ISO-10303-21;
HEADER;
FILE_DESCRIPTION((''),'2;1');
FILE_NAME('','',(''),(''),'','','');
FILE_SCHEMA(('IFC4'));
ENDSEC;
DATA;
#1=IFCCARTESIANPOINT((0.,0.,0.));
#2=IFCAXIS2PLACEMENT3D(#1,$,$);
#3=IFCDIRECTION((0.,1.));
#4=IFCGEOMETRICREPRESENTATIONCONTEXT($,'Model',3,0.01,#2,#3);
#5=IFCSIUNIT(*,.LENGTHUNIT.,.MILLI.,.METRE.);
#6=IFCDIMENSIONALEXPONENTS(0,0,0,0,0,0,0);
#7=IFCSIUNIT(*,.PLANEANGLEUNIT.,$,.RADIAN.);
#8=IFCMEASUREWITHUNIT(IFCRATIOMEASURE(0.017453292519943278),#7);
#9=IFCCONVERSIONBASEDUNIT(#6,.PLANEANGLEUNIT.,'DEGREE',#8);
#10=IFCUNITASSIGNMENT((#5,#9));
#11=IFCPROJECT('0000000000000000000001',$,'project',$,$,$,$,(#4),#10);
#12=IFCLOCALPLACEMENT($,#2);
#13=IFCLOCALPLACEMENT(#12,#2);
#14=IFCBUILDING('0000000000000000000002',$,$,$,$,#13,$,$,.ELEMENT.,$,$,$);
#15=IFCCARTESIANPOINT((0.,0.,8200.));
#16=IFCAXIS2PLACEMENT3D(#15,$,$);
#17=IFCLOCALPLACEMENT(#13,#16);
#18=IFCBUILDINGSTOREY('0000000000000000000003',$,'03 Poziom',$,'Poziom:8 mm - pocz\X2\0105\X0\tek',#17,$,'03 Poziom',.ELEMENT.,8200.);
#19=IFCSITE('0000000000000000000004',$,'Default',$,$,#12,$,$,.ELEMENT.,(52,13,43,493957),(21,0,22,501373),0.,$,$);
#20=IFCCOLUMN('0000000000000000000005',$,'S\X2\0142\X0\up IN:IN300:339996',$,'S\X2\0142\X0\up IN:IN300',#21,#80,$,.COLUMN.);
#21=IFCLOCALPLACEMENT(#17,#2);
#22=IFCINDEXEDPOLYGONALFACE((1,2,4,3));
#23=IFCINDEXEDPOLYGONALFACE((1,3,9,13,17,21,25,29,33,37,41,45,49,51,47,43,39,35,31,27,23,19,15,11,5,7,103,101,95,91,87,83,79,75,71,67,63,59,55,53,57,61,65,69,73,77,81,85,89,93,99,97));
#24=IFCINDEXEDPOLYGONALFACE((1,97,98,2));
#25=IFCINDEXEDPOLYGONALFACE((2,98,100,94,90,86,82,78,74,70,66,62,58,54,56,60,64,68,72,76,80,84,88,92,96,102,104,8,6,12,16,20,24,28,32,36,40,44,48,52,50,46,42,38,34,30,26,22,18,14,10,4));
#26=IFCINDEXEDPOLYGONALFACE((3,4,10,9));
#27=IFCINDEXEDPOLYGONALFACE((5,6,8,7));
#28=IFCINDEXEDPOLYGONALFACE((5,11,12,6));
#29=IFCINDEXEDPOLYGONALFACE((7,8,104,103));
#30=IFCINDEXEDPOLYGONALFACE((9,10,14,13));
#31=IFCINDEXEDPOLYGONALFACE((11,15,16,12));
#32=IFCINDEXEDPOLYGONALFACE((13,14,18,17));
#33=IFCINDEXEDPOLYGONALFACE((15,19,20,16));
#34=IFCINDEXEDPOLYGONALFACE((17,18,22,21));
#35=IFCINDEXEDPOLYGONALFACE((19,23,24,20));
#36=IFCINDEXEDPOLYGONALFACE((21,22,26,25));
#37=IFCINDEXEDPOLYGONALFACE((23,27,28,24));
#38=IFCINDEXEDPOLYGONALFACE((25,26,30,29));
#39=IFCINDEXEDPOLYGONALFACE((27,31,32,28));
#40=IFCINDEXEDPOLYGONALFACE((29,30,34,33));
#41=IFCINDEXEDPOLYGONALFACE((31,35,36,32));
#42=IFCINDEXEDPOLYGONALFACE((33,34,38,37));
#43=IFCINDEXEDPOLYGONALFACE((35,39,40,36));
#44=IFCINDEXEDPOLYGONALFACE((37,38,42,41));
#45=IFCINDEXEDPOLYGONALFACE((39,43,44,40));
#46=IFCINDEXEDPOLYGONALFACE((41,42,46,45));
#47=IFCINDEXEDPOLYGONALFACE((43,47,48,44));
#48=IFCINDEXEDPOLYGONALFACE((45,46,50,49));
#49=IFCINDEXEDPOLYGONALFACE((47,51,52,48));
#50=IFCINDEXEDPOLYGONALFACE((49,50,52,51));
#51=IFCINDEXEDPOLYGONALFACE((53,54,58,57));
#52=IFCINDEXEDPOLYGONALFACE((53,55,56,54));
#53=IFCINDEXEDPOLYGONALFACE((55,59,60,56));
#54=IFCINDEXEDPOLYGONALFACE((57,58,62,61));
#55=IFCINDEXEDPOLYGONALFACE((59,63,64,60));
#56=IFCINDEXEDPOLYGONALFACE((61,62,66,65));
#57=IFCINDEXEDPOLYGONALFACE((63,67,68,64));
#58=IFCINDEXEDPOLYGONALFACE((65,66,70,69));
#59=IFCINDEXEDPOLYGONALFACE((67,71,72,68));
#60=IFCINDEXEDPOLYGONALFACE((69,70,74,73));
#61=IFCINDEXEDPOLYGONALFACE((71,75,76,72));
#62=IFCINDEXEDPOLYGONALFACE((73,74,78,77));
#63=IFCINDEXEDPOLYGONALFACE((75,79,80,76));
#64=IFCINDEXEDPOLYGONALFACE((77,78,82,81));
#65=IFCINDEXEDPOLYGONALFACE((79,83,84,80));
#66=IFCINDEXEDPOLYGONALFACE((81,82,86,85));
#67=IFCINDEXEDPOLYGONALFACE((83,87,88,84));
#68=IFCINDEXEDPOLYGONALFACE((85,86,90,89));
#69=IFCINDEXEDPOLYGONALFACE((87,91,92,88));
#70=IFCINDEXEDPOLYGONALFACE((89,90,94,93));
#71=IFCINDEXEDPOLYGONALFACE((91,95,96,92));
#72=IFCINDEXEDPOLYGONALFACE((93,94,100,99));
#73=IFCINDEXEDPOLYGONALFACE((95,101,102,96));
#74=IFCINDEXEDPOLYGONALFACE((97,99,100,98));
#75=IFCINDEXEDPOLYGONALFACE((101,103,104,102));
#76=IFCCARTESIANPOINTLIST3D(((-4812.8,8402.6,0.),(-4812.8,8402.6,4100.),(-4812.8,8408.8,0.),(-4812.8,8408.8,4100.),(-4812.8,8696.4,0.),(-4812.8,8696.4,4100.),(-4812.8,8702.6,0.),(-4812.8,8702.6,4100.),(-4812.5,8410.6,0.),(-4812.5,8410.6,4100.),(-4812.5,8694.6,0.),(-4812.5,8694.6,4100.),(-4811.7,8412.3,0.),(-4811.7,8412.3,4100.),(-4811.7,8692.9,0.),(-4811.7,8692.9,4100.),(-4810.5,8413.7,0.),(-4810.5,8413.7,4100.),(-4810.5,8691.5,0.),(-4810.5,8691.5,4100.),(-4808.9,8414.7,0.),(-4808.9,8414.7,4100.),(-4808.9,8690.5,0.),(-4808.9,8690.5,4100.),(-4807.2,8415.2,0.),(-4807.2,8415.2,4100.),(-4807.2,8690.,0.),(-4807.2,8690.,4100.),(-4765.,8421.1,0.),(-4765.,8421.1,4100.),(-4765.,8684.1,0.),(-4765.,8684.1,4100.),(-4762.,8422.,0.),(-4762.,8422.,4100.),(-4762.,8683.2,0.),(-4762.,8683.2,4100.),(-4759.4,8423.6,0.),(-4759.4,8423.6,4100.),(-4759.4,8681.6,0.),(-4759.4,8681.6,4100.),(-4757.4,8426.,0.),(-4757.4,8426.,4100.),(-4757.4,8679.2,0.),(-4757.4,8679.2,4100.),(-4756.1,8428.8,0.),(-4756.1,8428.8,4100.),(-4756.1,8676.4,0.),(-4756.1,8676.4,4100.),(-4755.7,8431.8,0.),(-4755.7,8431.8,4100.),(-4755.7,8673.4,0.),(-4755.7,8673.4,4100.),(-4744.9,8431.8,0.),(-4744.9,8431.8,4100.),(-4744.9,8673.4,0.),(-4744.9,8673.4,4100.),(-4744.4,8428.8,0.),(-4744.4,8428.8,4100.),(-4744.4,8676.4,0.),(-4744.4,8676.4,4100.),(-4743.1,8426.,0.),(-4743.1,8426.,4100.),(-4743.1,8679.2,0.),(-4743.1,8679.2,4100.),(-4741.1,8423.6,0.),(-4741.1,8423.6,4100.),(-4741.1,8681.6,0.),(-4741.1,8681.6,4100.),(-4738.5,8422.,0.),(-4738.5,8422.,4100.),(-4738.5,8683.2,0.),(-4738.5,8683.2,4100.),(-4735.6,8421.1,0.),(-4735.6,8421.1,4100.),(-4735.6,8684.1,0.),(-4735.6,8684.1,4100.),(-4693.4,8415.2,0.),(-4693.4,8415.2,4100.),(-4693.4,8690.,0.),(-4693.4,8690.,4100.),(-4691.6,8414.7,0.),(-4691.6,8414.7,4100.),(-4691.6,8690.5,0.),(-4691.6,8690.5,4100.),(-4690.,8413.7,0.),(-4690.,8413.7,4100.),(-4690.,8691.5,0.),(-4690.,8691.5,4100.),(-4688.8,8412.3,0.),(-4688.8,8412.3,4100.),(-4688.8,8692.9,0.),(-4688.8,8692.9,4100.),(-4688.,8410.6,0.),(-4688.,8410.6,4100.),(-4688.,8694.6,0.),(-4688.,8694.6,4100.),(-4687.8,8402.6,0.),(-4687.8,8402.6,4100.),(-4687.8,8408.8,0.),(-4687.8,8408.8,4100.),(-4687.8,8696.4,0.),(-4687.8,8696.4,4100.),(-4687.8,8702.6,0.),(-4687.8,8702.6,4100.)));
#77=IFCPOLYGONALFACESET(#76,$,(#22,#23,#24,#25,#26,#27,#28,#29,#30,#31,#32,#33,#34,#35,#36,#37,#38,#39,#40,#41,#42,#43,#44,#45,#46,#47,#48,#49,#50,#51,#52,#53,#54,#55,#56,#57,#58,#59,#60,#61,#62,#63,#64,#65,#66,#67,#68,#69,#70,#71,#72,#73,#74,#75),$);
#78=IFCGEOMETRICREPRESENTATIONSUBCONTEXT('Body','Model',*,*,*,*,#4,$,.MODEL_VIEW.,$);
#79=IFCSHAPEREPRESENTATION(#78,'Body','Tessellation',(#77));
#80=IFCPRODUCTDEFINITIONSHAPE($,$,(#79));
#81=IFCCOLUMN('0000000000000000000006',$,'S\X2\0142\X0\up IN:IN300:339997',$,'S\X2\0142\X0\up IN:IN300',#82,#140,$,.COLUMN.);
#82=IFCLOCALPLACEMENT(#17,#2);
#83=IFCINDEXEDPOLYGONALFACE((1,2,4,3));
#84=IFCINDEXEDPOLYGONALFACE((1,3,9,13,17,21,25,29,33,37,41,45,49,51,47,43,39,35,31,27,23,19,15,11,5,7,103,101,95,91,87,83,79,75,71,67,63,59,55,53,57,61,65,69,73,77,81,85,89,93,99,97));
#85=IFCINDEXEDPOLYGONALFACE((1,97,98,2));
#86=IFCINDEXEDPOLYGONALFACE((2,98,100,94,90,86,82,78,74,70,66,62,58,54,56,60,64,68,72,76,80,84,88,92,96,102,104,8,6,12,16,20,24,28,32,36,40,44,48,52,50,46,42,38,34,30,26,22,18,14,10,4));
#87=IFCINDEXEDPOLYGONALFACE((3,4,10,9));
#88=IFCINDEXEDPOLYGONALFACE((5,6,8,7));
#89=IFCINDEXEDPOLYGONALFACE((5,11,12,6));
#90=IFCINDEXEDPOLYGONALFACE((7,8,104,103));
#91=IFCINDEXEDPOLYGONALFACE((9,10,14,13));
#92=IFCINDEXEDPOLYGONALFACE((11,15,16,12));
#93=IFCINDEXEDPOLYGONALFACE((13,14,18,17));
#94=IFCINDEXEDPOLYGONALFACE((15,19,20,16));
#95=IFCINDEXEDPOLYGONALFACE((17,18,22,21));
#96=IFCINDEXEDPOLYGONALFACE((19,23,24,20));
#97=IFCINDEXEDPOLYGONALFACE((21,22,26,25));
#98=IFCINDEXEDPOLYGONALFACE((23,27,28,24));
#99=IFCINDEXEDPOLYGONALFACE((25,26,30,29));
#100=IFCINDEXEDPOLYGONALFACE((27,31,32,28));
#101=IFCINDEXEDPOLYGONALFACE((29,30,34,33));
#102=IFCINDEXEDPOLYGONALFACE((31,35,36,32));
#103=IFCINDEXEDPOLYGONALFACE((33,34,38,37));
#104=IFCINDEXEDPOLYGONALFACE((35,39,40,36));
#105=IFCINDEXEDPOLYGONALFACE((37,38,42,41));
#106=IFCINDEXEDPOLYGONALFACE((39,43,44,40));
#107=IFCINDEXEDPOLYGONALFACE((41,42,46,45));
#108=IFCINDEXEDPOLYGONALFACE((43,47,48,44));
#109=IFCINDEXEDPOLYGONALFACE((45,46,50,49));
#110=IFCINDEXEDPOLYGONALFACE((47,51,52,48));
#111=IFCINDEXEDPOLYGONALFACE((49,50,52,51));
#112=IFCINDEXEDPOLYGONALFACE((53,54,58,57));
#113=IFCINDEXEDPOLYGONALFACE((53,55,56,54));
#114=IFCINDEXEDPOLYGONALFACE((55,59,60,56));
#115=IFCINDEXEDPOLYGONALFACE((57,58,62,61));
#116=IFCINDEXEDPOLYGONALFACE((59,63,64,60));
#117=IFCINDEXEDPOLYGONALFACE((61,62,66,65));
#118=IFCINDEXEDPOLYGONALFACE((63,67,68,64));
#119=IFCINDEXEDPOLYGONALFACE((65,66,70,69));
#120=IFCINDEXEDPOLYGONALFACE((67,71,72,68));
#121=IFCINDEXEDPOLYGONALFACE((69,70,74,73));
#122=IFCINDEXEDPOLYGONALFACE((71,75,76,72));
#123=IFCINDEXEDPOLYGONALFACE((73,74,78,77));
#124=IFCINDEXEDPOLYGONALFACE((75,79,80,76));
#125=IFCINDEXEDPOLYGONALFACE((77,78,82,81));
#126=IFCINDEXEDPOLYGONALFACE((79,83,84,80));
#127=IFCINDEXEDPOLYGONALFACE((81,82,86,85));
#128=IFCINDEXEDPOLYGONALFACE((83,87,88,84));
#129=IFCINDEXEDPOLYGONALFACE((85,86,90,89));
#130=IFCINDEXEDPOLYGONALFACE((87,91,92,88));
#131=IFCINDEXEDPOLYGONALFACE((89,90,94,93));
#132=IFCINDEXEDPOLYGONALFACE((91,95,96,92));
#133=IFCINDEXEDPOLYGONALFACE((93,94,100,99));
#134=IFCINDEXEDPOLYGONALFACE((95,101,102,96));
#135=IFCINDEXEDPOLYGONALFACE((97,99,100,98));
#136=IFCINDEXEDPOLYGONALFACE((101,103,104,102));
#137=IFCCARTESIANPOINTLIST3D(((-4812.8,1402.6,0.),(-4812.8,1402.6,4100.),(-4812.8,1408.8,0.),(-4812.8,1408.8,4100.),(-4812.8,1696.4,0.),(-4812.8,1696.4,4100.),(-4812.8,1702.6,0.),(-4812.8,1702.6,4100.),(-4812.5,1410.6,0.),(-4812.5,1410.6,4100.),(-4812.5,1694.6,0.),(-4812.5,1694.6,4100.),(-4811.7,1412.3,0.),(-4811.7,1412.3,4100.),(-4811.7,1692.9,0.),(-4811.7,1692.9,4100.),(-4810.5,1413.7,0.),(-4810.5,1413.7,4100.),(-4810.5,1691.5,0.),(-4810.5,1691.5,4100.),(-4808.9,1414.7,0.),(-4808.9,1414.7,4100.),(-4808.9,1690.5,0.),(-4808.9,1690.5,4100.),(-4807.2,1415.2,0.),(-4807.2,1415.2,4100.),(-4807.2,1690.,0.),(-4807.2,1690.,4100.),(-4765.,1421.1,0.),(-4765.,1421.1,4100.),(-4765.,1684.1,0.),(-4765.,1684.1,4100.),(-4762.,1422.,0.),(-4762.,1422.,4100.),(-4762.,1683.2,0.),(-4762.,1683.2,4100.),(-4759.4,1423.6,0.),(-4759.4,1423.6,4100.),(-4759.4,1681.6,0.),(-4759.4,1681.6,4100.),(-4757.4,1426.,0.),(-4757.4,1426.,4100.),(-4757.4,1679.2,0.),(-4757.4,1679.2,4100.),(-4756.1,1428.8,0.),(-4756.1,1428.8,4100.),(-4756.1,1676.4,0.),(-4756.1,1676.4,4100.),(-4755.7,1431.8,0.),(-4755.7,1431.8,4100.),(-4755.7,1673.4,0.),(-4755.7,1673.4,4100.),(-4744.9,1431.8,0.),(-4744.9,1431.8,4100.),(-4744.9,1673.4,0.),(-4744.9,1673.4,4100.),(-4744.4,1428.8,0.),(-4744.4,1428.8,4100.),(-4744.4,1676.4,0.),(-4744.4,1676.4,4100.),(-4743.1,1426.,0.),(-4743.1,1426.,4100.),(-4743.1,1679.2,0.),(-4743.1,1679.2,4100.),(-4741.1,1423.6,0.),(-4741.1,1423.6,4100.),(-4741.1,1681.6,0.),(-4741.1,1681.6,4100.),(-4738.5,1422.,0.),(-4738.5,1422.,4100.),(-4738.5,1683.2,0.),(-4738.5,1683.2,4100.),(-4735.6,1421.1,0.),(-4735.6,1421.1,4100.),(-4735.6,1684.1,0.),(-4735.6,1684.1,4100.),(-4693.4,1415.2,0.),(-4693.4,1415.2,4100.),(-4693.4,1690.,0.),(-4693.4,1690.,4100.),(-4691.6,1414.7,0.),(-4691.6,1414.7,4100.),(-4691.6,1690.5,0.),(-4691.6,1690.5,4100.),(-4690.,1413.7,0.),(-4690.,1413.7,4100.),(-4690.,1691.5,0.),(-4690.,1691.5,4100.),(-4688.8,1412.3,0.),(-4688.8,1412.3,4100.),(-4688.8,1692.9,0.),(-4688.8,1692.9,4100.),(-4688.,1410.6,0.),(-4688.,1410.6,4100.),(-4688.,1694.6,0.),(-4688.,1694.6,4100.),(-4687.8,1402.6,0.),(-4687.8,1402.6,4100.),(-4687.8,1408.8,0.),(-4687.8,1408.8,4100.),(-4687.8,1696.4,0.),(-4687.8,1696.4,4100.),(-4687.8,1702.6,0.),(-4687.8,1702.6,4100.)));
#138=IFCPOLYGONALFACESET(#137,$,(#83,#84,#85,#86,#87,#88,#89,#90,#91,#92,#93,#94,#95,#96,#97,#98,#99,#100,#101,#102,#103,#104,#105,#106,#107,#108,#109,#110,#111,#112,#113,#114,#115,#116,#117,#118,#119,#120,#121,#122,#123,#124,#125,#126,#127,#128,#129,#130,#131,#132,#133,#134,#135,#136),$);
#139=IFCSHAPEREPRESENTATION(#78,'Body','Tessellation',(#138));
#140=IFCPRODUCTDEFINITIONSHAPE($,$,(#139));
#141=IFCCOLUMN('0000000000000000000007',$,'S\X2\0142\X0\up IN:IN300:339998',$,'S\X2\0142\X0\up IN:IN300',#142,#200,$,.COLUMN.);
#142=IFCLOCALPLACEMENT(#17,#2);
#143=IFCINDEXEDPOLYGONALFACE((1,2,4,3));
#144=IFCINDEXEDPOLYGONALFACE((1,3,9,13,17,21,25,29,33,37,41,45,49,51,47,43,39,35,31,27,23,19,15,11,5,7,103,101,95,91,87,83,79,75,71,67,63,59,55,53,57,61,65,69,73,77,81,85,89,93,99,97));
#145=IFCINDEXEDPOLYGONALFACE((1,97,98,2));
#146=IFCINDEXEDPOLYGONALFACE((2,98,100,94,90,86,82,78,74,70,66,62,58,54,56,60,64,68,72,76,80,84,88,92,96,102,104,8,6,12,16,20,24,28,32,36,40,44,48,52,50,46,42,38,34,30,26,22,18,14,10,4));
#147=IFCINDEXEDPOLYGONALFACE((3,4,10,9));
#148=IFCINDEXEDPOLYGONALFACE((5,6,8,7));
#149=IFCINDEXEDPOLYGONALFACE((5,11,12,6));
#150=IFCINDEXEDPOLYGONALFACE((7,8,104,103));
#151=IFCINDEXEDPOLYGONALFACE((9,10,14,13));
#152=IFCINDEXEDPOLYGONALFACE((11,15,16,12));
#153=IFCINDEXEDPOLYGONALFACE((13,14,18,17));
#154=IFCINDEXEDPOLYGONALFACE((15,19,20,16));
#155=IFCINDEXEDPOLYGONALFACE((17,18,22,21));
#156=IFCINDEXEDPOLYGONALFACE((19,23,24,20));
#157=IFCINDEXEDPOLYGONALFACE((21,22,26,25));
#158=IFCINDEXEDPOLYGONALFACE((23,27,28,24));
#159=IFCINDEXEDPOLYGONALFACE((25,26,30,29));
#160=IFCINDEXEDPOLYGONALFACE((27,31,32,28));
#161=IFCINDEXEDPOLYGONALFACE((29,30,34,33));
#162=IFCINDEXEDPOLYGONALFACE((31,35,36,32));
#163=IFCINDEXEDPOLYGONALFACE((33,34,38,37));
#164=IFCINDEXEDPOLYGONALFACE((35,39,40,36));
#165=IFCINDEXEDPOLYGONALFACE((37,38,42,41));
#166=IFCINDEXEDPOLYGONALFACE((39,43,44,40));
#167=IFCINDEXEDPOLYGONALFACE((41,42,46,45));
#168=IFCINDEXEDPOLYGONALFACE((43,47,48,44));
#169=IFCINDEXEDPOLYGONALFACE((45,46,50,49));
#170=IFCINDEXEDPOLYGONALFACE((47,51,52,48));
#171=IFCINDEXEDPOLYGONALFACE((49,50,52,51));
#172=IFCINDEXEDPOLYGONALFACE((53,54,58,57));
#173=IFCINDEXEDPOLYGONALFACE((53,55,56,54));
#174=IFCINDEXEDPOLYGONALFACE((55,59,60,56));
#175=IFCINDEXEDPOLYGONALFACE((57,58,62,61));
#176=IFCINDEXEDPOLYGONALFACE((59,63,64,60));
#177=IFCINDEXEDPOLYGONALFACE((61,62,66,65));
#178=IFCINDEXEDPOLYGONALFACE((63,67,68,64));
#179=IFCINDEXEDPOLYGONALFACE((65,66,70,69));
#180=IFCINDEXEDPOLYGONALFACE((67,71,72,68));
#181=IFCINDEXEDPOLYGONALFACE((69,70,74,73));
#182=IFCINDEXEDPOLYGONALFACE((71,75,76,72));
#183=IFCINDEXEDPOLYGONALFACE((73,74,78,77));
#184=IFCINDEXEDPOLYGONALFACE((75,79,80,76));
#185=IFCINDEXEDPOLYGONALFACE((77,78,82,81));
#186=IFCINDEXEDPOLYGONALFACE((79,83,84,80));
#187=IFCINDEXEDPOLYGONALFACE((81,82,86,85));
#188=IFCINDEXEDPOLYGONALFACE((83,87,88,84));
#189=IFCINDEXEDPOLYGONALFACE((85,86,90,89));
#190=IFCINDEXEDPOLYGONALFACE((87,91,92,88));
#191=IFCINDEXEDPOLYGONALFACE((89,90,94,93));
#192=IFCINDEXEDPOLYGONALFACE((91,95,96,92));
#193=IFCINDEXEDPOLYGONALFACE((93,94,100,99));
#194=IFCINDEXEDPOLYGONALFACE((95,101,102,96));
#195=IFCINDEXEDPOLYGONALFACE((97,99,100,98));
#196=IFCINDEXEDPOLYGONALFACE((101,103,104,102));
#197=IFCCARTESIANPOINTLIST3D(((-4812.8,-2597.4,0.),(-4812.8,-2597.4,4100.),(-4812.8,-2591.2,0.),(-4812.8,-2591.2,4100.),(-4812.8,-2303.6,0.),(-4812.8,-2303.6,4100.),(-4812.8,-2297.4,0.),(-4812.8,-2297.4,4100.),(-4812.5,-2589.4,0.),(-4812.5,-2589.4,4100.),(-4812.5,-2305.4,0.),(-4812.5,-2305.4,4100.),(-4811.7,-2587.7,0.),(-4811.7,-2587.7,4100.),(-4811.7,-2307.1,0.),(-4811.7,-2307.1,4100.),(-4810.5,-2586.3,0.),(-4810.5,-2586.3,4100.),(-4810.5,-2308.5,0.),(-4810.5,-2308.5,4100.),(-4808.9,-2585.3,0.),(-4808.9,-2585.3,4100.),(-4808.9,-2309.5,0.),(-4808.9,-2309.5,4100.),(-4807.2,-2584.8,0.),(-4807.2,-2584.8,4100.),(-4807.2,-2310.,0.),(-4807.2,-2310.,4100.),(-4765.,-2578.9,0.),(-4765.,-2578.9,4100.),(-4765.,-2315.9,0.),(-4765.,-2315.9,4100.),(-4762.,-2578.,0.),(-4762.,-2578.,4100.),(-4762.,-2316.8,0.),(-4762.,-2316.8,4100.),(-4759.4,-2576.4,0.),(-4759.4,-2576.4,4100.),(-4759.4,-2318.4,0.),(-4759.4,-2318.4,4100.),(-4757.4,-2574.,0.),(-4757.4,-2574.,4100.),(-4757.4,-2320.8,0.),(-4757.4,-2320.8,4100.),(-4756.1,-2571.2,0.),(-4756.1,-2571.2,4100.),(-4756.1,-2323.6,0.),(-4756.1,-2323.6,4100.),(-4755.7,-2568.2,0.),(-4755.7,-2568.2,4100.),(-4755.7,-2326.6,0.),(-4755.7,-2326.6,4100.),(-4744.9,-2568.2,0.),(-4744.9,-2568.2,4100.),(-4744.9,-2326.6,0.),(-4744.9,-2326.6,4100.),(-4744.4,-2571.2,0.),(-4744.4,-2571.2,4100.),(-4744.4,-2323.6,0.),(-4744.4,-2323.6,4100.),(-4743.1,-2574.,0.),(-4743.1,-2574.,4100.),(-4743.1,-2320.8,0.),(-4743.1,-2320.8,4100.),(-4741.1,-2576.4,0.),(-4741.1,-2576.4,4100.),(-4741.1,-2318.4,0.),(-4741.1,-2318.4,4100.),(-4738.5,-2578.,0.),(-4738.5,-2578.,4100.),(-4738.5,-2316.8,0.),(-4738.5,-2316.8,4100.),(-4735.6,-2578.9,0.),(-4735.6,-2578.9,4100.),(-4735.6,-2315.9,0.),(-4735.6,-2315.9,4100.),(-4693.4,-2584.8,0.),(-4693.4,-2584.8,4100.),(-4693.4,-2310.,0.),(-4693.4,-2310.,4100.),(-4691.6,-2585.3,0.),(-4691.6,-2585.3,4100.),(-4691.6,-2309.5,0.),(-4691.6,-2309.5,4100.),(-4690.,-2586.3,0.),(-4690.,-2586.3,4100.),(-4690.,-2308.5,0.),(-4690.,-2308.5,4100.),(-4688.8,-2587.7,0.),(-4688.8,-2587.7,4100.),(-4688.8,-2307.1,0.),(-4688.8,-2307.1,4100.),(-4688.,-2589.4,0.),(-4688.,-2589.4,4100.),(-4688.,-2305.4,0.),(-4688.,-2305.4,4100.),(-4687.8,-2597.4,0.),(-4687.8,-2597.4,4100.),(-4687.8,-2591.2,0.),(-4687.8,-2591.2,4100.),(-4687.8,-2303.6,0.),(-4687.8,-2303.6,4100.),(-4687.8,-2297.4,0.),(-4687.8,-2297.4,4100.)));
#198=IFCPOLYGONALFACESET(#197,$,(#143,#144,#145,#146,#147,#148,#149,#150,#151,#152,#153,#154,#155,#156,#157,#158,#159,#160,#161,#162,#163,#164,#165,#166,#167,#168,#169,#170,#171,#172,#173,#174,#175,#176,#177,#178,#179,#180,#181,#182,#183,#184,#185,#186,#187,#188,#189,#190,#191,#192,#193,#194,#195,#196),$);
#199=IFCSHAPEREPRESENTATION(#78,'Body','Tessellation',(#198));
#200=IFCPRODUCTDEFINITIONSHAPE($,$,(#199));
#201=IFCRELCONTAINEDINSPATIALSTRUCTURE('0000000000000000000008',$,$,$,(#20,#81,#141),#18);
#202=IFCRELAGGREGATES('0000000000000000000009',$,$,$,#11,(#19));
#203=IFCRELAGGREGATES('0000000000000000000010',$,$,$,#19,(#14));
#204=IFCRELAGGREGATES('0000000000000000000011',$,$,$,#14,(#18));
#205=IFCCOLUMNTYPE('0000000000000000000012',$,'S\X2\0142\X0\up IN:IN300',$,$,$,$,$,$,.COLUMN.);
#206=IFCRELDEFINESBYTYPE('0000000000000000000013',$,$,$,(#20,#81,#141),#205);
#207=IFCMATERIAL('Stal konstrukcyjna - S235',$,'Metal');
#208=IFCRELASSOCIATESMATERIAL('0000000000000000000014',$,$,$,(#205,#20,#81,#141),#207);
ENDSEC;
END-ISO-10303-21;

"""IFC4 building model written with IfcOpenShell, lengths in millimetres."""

from ifc_helpers import new_model, entity, si_unit, converted_unit, direction, frame, origin, place, context, subcontext, project, spatial, line, arc, indexed_curve, outline, extrude, source, transform, mapped, material, type_object, type_shapes, element, save


model = new_model("IFC4")

# Units and contexts
model_context = context("Model", 3, precision=0.01, world=origin(), true_north=direction((0.0, 1.0)))
body_context = subcontext(model_context, "Body", "Model", "MODEL_VIEW")
ifc_project = project(units=[si_unit("LENGTHUNIT", "METRE", prefix="MILLI"), converted_unit("PLANEANGLEUNIT", "DEGREE", entity("IfcRatioMeasure", 0.017453292519943278), si_unit("PLANEANGLEUNIT", "RADIAN"), dimensions=[0, 0, 0, 0, 0, 0, 0])], contexts=[model_context])

# Site, building, storey
site_placement = place(None, origin())
site = spatial("IfcSite", under=ifc_project, at=site_placement, Name="Default", CompositionType="ELEMENT", RefLatitude=(52, 13, 43, 493957), RefLongitude=(21, 0, 22, 501373), RefElevation=0.0)
building_placement = place(site_placement, origin())
building = spatial("IfcBuilding", under=site, at=building_placement, CompositionType="ELEMENT")
storey_placement = place(building_placement, frame((0.0, 0.0, 8200.0)))
storey = spatial("IfcBuildingStorey", under=building, at=storey_placement, Name="03 Poziom", ObjectType="Poziom:8 mm - początek", LongName="03 Poziom", CompositionType="ELEMENT", Elevation=8200.0)

# Columns
ifc_material_1 = material(Name="Stal konstrukcyjna - S235", Category="Metal")
column_type = type_object("IfcColumnType", Name="Słup IN:IN300", PredefinedType="COLUMN", material=ifc_material_1)
shared_shape_1 = source(origin(), body_context, "Body", "SweptSolid", [
    extrude(outline(indexed_curve([(143.8, -62.5), (150.0, -62.5), (150.0, 62.5), (143.8, 62.5), (139.6, 60.9), (137.4, 56.9), (131.5, 14.7), (127.9, 8.1), (120.8, 5.4), (-120.8, 5.4), (-127.9, 8.1), (-131.5, 14.7), (-137.4, 56.9), (-139.6, 60.9), (-143.8, 62.5), (-150.0, 62.5), (-150.0, -62.5), (-143.8, -62.5), (-139.6, -60.9), (-137.4, -56.9), (-131.5, -14.7), (-127.9, -8.1), (-120.8, -5.4), (120.8, -5.4), (127.9, -8.1), (131.5, -14.7), (137.4, -56.9), (139.6, -60.9)], segments=[line(1, 2, 3, 4), arc(4, 5, 6), line(6, 7), arc(7, 8, 9), line(9, 10), arc(10, 11, 12), line(12, 13), arc(13, 14, 15), line(15, 16, 17, 18), arc(18, 19, 20), line(20, 21), arc(21, 22, 23), line(23, 24), arc(24, 25, 26), line(26, 27), arc(27, 28, 1)], self_intersect=False)), frame((0.0, 0.0, 8200.0), z_axis=(0.0, 0.0, 1.0), x_axis=(0.0, -1.0, 0.0)), (0.0, 0.0, 1.0), 4100.0),
])
type_shapes(column_type, [shared_shape_1])
for number, where, name in (
    (1, (-4750.3, 8552.6, -8200.0), "Słup IN:IN300:339996"),
    (2, (-4750.3, 1552.6, -8200.0), "Słup IN:IN300:339997"),
    (3, (-4750.3, -2447.4, -8200.0), "Słup IN:IN300:339998"),
):
    element("IfcColumn", number, at=place(storey_placement, frame(where)), inside=storey, type_object=column_type, material=ifc_material_1, Name=name, ObjectType="Słup IN:IN300", PredefinedType="COLUMN", context=body_context, shape_type="MappedRepresentation", body=[
        mapped(shared_shape_1, transform((0.0, 0.0, 0.0), scale=1.0)),
    ])

save(model, "model.ifc")
